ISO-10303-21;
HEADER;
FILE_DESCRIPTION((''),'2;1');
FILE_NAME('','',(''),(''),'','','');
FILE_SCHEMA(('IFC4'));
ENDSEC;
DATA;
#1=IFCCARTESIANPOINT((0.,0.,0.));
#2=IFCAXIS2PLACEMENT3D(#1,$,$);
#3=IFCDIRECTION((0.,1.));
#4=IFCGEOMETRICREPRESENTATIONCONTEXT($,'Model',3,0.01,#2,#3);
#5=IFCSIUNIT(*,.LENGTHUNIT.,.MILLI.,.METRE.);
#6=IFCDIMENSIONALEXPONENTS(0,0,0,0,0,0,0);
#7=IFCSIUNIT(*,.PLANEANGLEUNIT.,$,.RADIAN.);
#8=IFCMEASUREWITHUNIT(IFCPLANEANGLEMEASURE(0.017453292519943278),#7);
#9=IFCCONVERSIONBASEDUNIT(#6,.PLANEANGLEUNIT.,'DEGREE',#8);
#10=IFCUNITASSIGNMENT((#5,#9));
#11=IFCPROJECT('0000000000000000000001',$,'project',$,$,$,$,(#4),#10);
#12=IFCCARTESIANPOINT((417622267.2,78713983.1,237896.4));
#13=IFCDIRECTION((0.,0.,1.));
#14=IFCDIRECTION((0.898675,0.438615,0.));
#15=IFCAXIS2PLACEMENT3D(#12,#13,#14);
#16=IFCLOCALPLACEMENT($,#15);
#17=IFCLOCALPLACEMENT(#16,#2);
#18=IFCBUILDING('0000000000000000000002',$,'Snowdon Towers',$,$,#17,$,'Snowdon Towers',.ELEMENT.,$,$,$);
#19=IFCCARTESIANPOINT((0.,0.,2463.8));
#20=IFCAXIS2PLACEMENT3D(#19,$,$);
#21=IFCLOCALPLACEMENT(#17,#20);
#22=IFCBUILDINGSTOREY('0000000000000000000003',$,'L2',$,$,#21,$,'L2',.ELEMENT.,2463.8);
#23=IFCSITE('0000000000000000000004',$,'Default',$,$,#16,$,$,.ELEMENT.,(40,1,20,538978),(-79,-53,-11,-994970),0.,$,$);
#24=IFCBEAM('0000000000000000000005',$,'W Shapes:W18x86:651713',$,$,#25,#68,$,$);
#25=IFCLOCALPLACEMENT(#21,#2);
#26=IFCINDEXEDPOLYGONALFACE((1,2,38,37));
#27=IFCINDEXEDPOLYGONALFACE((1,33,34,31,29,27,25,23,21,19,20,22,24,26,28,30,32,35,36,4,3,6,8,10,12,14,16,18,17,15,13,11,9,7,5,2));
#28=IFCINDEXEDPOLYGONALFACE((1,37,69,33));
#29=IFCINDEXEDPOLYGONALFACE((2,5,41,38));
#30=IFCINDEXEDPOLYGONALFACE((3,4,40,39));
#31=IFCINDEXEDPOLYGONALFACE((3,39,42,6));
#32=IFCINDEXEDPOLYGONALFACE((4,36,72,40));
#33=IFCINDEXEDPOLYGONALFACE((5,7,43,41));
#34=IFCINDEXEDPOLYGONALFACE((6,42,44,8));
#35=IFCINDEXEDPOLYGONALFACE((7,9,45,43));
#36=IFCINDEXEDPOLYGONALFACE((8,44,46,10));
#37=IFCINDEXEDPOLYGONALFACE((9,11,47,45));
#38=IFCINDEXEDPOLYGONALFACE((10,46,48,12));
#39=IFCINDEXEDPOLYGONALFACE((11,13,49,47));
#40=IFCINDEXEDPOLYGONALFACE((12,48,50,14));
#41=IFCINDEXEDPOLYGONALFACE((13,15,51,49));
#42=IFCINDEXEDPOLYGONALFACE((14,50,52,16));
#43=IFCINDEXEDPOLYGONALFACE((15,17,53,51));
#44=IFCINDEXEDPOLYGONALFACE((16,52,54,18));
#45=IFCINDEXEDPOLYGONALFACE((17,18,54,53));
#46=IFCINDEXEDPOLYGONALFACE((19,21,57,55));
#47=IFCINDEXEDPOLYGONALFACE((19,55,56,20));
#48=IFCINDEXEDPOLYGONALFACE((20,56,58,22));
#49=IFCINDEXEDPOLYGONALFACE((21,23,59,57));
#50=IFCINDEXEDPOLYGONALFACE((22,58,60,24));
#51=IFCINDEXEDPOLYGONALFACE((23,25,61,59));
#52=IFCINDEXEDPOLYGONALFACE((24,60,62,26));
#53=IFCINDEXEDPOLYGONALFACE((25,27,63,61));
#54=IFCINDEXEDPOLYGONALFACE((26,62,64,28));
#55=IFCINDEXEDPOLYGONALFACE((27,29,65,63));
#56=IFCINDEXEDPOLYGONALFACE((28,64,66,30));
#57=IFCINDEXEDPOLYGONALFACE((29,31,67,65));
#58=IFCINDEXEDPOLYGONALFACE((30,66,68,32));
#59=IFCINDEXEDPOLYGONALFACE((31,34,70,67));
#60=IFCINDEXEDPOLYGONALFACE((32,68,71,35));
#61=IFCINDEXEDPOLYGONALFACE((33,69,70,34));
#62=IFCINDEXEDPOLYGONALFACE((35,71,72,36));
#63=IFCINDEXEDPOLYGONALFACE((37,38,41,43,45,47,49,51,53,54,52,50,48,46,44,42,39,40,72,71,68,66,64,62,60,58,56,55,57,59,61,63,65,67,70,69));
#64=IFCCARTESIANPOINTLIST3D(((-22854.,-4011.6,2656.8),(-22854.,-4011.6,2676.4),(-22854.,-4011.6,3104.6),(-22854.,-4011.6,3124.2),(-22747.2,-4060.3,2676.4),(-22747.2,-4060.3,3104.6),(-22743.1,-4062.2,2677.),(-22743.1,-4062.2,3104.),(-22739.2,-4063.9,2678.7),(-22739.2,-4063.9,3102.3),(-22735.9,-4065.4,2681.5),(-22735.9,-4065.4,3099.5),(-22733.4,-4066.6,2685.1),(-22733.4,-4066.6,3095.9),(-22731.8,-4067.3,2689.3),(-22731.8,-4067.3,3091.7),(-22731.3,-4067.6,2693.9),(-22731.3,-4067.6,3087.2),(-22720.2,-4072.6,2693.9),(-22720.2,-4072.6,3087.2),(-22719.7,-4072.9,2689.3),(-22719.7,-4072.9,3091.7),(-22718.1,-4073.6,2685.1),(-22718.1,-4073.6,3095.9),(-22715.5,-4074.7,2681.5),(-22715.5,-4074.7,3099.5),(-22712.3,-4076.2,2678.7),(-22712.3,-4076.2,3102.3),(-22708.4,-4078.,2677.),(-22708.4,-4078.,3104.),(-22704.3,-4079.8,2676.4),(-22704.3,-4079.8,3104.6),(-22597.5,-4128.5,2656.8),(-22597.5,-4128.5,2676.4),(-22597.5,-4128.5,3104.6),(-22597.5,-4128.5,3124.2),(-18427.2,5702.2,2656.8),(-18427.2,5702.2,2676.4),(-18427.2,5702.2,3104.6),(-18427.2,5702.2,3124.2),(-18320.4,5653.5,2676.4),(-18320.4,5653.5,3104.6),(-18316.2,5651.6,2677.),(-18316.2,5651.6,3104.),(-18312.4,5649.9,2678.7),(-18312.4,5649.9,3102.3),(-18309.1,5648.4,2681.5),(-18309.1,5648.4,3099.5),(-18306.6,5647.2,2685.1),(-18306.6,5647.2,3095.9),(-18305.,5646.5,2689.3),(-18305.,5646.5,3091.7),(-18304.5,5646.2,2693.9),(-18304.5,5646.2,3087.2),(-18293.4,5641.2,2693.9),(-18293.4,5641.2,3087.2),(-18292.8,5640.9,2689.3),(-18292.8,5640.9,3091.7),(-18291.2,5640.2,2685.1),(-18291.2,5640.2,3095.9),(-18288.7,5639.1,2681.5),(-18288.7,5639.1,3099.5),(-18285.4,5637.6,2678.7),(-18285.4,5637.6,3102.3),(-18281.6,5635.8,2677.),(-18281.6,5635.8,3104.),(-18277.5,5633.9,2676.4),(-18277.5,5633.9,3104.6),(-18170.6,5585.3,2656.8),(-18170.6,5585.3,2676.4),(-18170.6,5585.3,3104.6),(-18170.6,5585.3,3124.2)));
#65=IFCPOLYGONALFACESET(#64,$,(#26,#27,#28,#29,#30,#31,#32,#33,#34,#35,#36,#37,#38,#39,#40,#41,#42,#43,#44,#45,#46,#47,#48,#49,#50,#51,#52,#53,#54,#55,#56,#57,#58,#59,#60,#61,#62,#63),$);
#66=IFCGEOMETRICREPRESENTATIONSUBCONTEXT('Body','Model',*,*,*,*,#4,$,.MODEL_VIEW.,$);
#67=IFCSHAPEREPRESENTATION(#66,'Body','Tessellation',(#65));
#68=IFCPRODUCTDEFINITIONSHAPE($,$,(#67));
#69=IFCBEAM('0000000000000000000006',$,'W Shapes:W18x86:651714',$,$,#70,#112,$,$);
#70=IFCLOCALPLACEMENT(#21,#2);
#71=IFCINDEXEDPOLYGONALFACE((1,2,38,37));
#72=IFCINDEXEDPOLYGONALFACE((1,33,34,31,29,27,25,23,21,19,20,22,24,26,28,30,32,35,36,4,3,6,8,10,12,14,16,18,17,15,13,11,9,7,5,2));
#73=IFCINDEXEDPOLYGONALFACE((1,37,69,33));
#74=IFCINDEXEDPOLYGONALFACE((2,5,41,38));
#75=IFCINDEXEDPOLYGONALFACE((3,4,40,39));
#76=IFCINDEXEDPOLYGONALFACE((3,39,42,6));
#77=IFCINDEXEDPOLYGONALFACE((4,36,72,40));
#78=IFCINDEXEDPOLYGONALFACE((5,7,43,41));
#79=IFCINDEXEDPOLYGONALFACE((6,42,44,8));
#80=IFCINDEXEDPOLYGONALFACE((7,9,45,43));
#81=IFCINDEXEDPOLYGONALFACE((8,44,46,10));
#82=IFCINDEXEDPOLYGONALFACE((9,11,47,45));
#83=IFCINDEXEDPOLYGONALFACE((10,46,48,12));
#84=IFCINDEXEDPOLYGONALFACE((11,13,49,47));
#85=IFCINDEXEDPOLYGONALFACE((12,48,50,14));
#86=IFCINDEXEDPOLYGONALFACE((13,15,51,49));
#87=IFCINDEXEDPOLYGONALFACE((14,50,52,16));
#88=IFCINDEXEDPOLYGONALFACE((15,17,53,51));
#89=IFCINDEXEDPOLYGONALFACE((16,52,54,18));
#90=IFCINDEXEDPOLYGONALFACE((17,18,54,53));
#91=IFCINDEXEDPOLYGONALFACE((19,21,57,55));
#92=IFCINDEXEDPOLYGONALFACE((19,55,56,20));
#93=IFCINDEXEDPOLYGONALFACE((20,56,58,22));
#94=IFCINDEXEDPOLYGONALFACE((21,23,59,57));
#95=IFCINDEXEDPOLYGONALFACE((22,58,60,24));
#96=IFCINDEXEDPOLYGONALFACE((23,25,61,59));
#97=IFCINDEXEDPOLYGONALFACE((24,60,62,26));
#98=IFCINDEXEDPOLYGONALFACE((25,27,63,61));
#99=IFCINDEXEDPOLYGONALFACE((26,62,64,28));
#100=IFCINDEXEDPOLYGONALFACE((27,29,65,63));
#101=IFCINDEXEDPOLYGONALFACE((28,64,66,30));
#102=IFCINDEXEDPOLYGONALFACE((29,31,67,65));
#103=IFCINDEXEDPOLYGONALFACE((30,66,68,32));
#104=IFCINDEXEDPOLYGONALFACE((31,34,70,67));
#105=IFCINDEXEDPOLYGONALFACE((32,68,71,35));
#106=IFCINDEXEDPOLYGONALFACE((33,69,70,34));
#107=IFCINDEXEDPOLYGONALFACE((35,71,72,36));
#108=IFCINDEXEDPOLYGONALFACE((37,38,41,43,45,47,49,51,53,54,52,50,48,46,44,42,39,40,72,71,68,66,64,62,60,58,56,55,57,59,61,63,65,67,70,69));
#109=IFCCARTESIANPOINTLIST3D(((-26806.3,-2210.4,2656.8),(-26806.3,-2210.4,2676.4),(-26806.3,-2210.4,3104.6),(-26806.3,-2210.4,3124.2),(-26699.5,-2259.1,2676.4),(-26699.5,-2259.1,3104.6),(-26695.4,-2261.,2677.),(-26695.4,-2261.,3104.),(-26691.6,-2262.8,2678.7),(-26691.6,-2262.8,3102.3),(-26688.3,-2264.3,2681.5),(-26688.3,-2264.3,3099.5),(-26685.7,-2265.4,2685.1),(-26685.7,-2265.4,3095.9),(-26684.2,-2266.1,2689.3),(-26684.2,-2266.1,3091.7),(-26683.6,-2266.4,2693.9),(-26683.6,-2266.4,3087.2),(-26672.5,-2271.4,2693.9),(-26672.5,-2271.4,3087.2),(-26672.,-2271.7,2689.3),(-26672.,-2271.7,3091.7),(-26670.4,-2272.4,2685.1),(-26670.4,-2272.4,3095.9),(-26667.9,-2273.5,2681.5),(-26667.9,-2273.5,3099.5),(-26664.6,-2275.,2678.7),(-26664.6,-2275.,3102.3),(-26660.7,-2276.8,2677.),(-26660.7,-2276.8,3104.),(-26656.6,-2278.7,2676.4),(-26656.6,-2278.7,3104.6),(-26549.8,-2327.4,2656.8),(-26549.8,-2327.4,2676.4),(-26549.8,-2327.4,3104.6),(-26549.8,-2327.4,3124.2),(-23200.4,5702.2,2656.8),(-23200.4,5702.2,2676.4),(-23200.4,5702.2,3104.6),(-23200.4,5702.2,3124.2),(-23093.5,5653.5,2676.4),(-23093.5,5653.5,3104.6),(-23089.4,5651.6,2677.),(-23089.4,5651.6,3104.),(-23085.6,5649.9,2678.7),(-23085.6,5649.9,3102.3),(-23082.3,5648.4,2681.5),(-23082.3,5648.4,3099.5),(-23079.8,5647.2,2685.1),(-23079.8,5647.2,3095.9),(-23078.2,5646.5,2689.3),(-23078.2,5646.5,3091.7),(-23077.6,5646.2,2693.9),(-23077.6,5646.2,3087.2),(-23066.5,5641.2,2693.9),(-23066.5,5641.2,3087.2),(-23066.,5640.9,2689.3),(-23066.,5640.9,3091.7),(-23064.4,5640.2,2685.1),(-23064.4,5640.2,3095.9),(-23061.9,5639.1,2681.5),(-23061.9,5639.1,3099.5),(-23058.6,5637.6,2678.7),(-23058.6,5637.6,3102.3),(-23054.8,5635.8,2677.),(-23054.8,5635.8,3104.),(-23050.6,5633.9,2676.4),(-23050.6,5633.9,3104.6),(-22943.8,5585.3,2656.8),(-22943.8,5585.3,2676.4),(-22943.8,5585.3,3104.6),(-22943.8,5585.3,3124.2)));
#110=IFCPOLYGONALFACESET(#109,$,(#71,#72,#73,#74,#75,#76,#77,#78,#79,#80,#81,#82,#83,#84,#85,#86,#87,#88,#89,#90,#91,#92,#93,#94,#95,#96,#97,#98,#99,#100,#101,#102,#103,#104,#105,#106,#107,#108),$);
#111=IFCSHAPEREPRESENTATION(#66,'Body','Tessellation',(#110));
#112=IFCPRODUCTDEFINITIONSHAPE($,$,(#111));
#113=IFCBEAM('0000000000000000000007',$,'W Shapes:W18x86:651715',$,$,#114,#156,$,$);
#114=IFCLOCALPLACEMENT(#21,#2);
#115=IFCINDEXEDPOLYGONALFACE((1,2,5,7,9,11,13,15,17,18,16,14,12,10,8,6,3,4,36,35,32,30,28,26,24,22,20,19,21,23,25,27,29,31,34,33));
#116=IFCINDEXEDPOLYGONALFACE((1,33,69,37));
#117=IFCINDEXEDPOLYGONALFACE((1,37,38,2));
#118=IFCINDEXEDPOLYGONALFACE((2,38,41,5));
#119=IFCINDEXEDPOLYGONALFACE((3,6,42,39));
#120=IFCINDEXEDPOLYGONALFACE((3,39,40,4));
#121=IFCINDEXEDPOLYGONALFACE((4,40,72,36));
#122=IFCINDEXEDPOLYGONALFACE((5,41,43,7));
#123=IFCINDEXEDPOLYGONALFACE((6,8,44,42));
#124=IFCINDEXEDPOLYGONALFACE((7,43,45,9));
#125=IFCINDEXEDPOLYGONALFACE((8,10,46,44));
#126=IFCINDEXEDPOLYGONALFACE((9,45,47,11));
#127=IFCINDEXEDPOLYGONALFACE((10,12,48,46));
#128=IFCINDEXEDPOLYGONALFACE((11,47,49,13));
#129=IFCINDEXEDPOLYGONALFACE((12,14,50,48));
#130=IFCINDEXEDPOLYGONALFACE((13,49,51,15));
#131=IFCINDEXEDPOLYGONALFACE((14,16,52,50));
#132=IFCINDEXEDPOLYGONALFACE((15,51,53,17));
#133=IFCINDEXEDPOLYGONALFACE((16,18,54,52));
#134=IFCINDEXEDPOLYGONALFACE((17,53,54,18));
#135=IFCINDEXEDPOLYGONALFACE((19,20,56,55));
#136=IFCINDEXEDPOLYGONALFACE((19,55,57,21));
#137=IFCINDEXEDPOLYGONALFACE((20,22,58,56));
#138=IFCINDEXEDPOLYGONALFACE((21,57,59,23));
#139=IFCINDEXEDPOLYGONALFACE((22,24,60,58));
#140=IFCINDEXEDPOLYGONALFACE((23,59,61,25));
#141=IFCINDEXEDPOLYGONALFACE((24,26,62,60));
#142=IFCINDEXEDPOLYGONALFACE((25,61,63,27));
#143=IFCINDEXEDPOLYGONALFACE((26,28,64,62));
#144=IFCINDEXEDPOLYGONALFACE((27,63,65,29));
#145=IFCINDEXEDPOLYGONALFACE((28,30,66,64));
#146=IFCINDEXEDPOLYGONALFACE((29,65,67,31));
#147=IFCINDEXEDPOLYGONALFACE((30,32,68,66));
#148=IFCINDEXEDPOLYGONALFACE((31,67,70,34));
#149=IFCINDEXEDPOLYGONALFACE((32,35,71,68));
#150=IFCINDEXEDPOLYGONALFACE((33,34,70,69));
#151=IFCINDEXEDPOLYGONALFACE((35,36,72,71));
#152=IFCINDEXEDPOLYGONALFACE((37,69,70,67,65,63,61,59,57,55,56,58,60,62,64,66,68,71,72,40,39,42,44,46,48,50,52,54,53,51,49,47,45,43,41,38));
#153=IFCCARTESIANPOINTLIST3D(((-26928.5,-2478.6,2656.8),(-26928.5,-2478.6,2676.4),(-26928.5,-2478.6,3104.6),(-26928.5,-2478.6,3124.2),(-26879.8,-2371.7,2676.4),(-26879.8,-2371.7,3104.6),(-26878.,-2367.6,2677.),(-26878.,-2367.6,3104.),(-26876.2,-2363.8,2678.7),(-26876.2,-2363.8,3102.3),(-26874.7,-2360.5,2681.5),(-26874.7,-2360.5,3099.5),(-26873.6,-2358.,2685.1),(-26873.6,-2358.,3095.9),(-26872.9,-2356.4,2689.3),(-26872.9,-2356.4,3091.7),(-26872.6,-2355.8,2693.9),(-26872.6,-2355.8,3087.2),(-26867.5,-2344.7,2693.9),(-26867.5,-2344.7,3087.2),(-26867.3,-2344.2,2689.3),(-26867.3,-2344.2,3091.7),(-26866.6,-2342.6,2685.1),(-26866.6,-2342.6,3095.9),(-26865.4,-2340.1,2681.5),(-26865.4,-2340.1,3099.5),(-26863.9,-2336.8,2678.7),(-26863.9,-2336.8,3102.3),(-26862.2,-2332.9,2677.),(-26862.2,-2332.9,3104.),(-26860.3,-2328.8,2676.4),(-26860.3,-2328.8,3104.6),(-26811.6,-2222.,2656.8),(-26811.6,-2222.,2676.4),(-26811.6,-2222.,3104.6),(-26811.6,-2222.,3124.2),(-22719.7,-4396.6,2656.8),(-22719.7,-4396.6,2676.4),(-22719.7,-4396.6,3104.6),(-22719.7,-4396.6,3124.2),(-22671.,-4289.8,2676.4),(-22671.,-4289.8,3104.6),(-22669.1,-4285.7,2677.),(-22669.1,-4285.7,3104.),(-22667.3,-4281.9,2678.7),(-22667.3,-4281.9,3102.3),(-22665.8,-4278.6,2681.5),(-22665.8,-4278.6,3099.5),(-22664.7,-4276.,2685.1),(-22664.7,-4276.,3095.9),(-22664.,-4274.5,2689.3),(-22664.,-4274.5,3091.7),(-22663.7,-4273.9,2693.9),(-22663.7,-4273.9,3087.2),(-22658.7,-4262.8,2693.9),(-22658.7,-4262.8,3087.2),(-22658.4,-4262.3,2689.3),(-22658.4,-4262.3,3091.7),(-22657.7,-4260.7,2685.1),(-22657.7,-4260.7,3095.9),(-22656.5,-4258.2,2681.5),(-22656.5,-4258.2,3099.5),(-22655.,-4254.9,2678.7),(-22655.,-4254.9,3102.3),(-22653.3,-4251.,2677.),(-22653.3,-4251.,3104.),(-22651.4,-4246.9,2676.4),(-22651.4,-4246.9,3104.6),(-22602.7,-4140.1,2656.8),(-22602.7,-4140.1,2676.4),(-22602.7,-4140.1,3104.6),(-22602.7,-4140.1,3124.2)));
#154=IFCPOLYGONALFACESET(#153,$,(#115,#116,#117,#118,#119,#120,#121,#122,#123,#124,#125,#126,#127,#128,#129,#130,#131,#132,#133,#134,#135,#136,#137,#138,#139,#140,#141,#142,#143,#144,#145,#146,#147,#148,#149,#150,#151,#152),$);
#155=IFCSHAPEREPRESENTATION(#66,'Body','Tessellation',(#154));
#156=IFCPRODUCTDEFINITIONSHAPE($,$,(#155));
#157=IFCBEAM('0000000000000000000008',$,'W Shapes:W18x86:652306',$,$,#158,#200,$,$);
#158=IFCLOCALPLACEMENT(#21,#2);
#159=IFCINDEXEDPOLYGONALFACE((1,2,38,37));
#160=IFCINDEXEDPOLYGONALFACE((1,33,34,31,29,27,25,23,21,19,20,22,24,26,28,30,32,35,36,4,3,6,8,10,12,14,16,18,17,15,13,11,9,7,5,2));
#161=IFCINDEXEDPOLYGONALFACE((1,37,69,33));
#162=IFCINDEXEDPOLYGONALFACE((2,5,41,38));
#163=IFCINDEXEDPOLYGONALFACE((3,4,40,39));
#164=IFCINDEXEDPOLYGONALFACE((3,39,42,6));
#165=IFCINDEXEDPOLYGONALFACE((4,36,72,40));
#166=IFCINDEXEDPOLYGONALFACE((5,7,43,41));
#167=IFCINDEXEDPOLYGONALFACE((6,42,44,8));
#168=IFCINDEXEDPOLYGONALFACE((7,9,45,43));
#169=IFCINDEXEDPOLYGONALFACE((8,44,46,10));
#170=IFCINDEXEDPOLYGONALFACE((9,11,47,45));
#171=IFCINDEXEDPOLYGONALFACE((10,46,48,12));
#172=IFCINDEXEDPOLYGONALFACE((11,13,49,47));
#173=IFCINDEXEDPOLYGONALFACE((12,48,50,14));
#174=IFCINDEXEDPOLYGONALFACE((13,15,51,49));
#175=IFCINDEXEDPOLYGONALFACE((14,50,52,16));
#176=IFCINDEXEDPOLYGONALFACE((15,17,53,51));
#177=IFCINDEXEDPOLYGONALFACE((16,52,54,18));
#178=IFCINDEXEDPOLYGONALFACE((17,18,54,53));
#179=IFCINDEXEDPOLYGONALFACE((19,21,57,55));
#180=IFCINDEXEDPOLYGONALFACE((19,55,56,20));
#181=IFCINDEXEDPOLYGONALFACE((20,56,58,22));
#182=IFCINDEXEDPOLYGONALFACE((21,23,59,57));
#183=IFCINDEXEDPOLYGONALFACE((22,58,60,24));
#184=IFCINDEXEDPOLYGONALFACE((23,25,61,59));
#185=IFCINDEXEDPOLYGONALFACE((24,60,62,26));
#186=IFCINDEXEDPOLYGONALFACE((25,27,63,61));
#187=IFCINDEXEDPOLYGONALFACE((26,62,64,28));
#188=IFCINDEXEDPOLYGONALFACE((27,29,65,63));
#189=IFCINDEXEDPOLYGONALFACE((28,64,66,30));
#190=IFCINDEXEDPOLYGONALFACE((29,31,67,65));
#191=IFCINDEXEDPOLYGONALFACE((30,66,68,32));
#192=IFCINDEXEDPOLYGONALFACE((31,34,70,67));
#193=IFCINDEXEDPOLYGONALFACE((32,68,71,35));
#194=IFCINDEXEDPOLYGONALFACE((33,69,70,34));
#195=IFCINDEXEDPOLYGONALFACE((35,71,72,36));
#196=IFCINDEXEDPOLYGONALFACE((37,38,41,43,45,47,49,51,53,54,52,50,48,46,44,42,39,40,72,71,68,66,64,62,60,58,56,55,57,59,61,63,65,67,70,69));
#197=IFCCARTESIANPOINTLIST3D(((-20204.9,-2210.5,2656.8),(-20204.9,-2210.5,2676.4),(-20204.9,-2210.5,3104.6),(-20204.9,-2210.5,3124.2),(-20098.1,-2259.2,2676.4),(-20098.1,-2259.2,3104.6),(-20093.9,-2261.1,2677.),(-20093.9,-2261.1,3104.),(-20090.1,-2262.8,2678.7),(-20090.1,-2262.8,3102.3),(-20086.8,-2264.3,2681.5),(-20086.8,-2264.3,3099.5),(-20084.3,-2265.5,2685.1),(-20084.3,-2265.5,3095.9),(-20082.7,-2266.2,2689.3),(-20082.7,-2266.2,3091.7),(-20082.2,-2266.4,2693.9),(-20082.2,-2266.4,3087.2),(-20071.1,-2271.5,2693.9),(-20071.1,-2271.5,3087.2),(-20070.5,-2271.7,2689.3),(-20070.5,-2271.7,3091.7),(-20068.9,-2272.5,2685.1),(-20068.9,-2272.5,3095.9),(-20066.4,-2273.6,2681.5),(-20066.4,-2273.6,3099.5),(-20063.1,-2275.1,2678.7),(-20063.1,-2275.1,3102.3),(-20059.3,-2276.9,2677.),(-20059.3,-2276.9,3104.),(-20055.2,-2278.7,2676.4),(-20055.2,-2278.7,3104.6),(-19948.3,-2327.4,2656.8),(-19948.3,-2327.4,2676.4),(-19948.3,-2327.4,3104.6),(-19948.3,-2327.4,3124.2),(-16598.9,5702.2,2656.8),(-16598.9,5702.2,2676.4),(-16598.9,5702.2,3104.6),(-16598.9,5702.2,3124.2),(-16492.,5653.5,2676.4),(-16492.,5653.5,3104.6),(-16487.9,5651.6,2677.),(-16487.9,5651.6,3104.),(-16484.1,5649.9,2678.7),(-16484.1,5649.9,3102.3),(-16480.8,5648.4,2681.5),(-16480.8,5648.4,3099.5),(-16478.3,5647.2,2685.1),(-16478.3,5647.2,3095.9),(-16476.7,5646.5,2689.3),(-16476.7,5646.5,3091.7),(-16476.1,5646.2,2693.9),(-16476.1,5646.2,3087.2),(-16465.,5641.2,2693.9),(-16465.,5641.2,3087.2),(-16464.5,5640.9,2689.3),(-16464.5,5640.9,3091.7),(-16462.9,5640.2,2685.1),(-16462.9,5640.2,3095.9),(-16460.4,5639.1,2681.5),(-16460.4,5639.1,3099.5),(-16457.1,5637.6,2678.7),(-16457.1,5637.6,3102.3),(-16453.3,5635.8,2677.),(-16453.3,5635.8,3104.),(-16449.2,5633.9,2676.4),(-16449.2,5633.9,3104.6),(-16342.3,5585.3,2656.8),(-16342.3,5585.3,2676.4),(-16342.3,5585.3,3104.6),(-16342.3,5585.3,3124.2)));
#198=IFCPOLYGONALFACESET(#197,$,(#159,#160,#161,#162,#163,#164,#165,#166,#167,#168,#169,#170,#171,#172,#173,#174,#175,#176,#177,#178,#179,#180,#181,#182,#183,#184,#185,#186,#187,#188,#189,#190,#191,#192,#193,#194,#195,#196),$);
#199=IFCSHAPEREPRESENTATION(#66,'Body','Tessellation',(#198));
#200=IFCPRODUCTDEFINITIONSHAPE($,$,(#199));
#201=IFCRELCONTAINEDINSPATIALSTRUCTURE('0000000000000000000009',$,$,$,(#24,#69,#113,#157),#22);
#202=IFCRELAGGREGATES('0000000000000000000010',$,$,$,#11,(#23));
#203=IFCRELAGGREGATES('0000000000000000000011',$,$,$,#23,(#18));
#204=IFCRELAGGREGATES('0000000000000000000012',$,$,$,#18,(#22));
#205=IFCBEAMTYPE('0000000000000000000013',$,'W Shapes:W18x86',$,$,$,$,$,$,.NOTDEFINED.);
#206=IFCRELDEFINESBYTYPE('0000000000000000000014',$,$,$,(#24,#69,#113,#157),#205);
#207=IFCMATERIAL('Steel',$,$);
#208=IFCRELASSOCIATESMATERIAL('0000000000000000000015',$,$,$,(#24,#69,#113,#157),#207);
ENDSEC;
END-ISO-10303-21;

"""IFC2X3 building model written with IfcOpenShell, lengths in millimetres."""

from ifc_helpers import new_model, entity, si_unit, converted_unit, direction, frame, frame_2d, origin, place, context, subcontext, project, spatial, i_section, extrude, material, type_object, element, save


model = new_model("IFC2X3")

# Units and contexts
model_context = context("Model", 3, precision=0.01, world=origin(), true_north=direction((0.0, 1.0)))
body_context = subcontext(model_context, "Body", "Model", "MODEL_VIEW")
ifc_project = project(units=[si_unit("LENGTHUNIT", "METRE", prefix="MILLI"), converted_unit("PLANEANGLEUNIT", "DEGREE", entity("IfcPlaneAngleMeasure", 0.017453292519943278), si_unit("PLANEANGLEUNIT", "RADIAN"), dimensions=[0, 0, 0, 0, 0, 0, 0])], contexts=[model_context])

# Site, building, storey
site_placement = place(None, frame((417622267.2, 78713983.1, 237896.4), z_axis=(0.0, 0.0, 1.0), x_axis=(0.898675, 0.438615, 0.0)))
site = spatial("IfcSite", under=ifc_project, at=site_placement, Name="Default", CompositionType="ELEMENT", RefLatitude=(40, 1, 20, 538978), RefLongitude=(-79, -53, -11, -994970), RefElevation=0.0)
building_placement = place(site_placement, origin())
building = spatial("IfcBuilding", under=site, at=building_placement, Name="Snowdon Towers", LongName="Snowdon Towers", CompositionType="ELEMENT")
storey_placement = place(building_placement, frame((0.0, 0.0, 2463.8)))
storey = spatial("IfcBuildingStorey", under=building, at=storey_placement, Name="L2", LongName="L2", CompositionType="ELEMENT", Elevation=2463.8)

# Beams
ifc_material = material(Name="Steel")
beam_type_1 = type_object("IfcBeamType", Name="W Shapes:W18x86", PredefinedType="NOTDEFINED")
beam_1_placement = place(storey_placement, frame((-22789.5, -4209.9, 3124.2), z_axis=(0.0, 0.0, 1.0), x_axis=(0.414693, 0.909961, 0.0)))
element("IfcBeam", 1, at=beam_1_placement, inside=storey, type_object=beam_type_1, material=ifc_material, Name="W Shapes:W18x86:651713", context=body_context, shape_type="SweptSolid", body=[
    extrude(i_section(OverallWidth=281.9, OverallDepth=467.4, WebThickness=12.2, FlangeThickness=19.6, FilletRadius=17.5, at=frame_2d((0.0, 0.0), x_axis=(0.0, 1.0))), frame((153.7, 0.0, -233.7), z_axis=(1.0, 0.0, 0.0), x_axis=(0.0, 0.0, -1.0)), (0.0, 0.0, 1.0), 10675.0),
])
beam_2_placement = place(storey_placement, frame((-26741.8, -2408.7, 3124.2), z_axis=(0.0, 0.0, 1.0), x_axis=(0.414693, 0.909961, 0.0)))
element("IfcBeam", 2, at=beam_2_placement, inside=storey, type_object=beam_type_1, material=ifc_material, Name="W Shapes:W18x86:651714", context=body_context, shape_type="SweptSolid", body=[
    extrude(i_section(OverallWidth=281.9, OverallDepth=467.4, WebThickness=12.2, FlangeThickness=19.6, FilletRadius=17.5, at=frame_2d((0.0, 0.0), x_axis=(0.0, 1.0))), frame((153.7, 0.0, -233.7), z_axis=(1.0, 0.0, 0.0), x_axis=(0.0, 0.0, -1.0)), (0.0, 0.0, 1.0), 8695.6),
])
beam_3_placement = place(storey_placement, frame((-26741.8, -2408.7, 3124.2), z_axis=(0.0, 0.0, 1.0), x_axis=(0.909961, -0.414693, 0.0)))
element("IfcBeam", 3, at=beam_3_placement, inside=storey, type_object=beam_type_1, material=ifc_material, Name="W Shapes:W18x86:651715", context=body_context, shape_type="SweptSolid", body=[
    extrude(i_section(OverallWidth=281.9, OverallDepth=467.4, WebThickness=12.2, FlangeThickness=19.6, FilletRadius=17.5, at=frame_2d((0.0, 0.0), x_axis=(0.0, 1.0))), frame((-141.0, 0.0, -233.7), z_axis=(1.0, 0.0, 0.0), x_axis=(0.0, 0.0, -1.0)), (0.0, 0.0, 1.0), 4625.3),
])
beam_4_placement = place(storey_placement, frame((-20140.3, -2408.8, 3124.2), z_axis=(0.0, 0.0, 1.0), x_axis=(0.414693, 0.909961, 0.0)))
element("IfcBeam", 4, at=beam_4_placement, inside=storey, type_object=beam_type_1, material=ifc_material, Name="W Shapes:W18x86:652306", context=body_context, shape_type="SweptSolid", body=[
    extrude(i_section(OverallWidth=281.9, OverallDepth=467.4, WebThickness=12.2, FlangeThickness=19.6, FilletRadius=17.5, at=frame_2d((0.0, 0.0), x_axis=(0.0, 1.0))), frame((153.7, 0.0, -233.7), z_axis=(1.0, 0.0, 0.0), x_axis=(0.0, 0.0, -1.0)), (0.0, 0.0, 1.0), 8695.6),
])

save(model, "model.ifc")
